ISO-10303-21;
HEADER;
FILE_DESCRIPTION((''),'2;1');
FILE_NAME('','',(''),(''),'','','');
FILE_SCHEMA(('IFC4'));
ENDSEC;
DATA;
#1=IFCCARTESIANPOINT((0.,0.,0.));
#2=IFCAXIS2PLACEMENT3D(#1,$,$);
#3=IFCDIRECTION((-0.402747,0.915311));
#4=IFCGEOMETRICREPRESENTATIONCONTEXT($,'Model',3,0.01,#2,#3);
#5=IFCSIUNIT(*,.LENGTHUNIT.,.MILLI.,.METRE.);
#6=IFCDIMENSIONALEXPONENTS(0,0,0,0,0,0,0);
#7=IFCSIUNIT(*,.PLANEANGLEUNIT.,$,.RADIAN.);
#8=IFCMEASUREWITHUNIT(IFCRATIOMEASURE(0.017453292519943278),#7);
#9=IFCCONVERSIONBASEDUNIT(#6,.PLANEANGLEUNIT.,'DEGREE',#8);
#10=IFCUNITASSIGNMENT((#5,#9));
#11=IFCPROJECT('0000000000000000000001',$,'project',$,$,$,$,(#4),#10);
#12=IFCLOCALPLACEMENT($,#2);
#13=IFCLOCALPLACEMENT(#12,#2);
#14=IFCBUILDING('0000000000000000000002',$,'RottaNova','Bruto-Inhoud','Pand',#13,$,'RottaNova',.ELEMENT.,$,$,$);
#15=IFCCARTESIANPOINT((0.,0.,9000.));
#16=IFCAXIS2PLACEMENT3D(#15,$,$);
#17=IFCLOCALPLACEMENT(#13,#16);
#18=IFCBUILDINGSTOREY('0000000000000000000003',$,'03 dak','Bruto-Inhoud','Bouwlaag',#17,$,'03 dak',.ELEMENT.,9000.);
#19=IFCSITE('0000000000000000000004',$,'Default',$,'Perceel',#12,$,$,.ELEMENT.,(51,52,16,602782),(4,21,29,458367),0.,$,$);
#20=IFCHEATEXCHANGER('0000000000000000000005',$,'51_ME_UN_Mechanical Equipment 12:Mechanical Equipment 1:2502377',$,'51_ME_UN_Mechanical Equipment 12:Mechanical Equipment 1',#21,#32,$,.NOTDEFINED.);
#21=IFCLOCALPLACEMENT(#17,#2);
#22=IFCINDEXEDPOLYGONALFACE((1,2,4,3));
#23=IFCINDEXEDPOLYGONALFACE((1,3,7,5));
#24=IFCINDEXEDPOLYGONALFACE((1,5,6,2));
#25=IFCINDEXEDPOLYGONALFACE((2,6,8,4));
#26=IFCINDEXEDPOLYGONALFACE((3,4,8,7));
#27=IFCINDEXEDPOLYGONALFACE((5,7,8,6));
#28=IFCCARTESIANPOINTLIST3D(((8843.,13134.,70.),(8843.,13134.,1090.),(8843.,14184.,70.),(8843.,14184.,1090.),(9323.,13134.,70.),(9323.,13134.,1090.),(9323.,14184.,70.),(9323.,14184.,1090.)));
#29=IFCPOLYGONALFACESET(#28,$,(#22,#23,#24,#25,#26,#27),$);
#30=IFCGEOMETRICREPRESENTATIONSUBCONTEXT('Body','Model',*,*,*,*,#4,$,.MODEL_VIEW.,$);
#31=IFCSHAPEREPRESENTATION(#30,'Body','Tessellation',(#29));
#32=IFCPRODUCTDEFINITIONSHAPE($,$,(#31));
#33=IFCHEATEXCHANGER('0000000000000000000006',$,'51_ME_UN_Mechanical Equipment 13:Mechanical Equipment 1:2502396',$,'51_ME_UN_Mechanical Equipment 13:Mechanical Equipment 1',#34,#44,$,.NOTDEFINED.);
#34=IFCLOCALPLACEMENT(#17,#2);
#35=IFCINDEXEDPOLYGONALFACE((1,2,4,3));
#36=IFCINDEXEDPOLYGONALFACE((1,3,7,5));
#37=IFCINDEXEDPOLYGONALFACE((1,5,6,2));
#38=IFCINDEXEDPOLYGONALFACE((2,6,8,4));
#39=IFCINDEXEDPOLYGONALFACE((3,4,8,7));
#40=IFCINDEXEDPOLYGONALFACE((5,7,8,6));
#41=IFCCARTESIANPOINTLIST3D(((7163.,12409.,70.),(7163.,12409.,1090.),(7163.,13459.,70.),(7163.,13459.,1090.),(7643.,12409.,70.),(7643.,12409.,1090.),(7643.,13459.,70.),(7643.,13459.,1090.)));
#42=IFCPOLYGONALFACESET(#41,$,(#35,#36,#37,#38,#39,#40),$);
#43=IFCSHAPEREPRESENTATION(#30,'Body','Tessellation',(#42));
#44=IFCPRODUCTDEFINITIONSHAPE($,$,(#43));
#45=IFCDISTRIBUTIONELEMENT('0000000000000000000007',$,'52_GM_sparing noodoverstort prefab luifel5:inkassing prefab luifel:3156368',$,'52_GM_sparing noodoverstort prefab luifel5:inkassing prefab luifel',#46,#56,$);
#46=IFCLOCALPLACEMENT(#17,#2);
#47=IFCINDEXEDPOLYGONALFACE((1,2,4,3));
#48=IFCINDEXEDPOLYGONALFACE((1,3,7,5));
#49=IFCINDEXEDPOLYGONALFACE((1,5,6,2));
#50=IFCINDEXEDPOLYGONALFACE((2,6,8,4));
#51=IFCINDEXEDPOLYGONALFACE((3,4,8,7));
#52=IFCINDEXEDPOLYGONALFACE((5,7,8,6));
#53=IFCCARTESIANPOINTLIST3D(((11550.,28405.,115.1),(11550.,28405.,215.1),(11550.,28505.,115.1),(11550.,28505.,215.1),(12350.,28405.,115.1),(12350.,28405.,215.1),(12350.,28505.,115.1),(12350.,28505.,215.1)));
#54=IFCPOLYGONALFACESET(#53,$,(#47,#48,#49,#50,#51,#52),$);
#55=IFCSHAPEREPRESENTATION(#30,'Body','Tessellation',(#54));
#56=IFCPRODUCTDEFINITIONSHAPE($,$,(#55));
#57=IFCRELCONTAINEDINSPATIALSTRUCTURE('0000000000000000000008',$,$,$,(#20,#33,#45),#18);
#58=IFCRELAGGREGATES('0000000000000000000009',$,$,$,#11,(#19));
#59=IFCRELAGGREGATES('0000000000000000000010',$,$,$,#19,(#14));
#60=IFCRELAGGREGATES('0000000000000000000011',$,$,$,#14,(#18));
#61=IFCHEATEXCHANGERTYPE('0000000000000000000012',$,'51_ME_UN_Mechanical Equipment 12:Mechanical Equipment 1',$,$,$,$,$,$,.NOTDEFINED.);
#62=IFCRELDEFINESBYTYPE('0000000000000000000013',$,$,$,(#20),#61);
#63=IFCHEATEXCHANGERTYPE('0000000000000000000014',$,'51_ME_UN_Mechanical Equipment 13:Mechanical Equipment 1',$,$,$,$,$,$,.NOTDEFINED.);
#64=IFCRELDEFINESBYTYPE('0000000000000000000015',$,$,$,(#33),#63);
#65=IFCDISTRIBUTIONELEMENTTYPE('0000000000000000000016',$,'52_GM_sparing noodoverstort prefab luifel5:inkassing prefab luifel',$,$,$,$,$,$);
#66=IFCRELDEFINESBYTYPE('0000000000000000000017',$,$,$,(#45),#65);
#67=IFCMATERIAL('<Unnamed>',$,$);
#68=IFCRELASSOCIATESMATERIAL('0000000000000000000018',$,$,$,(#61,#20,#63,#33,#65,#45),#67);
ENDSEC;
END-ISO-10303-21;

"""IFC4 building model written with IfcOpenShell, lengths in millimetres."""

from ifc_helpers import new_model, entity, si_unit, converted_unit, direction, frame, frame_2d, origin, origin_2d_with_axis, place, context, subcontext, project, spatial, rectangle, extrude, source, transform, mapped, material, type_object, type_shapes, element, save


model = new_model("IFC4")

# Units and contexts
model_context = context("Model", 3, precision=0.01, world=origin(), true_north=direction((-0.402747, 0.915311)))
body_context = subcontext(model_context, "Body", "Model", "MODEL_VIEW")
ifc_project = project(units=[si_unit("LENGTHUNIT", "METRE", prefix="MILLI"), converted_unit("PLANEANGLEUNIT", "DEGREE", entity("IfcRatioMeasure", 0.017453292519943278), si_unit("PLANEANGLEUNIT", "RADIAN"), dimensions=[0, 0, 0, 0, 0, 0, 0])], contexts=[model_context])

# Site, building, storey
site_placement = place(None, origin())
site = spatial("IfcSite", under=ifc_project, at=site_placement, Name="Default", ObjectType="Perceel", CompositionType="ELEMENT", RefLatitude=(51, 52, 16, 602782), RefLongitude=(4, 21, 29, 458367), RefElevation=0.0)
building_placement = place(site_placement, origin())
building = spatial("IfcBuilding", under=site, at=building_placement, Name="RottaNova", Description="Bruto-Inhoud", ObjectType="Pand", LongName="RottaNova", CompositionType="ELEMENT")
storey_placement = place(building_placement, frame((0.0, 0.0, 9000.0)))
storey = spatial("IfcBuildingStorey", under=building, at=storey_placement, Name="03 dak", Description="Bruto-Inhoud", ObjectType="Bouwlaag", LongName="03 dak", CompositionType="ELEMENT", Elevation=9000.0)

# Heat exchangers
ifc_material_1 = material(Name="<Unnamed>")
heat_exchanger_type_1 = type_object("IfcHeatExchangerType", Name="51_ME_UN_Mechanical Equipment 12:Mechanical Equipment 1", PredefinedType="NOTDEFINED", material=ifc_material_1)
shared_shape_1 = source(origin(), body_context, "Body", "SweptSolid", [
    extrude(rectangle(XDim=1050.0, YDim=480.0, at=frame_2d((0.0, 0.0), x_axis=(1.0, 0.0))), frame((525.0, 240.0, 0.0), z_axis=(0.0, 0.0, 1.0), x_axis=(-1.0, 0.0, 0.0)), (0.0, 0.0, 1.0), 1020.0),
])
type_shapes(heat_exchanger_type_1, [shared_shape_1])
heat_exchanger_1_placement = place(storey_placement, frame((9323.0, 13134.0, 70.0), z_axis=(0.0, 0.0, 1.0), x_axis=(0.0, 1.0, 0.0)))
element("IfcHeatExchanger", 1, at=heat_exchanger_1_placement, inside=storey, type_object=heat_exchanger_type_1, material=ifc_material_1, Name="51_ME_UN_Mechanical Equipment 12:Mechanical Equipment 1:2502377", ObjectType="51_ME_UN_Mechanical Equipment 12:Mechanical Equipment 1", PredefinedType="NOTDEFINED", context=body_context, shape_type="MappedRepresentation", body=[
    mapped(shared_shape_1, transform((0.0, 0.0, 0.0), scale=1.0)),
])
heat_exchanger_type_2 = type_object("IfcHeatExchangerType", Name="51_ME_UN_Mechanical Equipment 13:Mechanical Equipment 1", PredefinedType="NOTDEFINED", material=ifc_material_1)
shared_shape_2 = source(origin(), body_context, "Body", "SweptSolid", [
    extrude(rectangle(XDim=1050.0, YDim=480.0, at=frame_2d((0.0, 0.0), x_axis=(1.0, 0.0))), frame((525.0, 240.0, 0.0), z_axis=(0.0, 0.0, 1.0), x_axis=(-1.0, 0.0, 0.0)), (0.0, 0.0, 1.0), 1020.0),
])
type_shapes(heat_exchanger_type_2, [shared_shape_2])
heat_exchanger_2_placement = place(storey_placement, frame((7643.0, 12409.0, 70.0), z_axis=(0.0, 0.0, 1.0), x_axis=(0.0, 1.0, 0.0)))
element("IfcHeatExchanger", 2, at=heat_exchanger_2_placement, inside=storey, type_object=heat_exchanger_type_2, material=ifc_material_1, Name="51_ME_UN_Mechanical Equipment 13:Mechanical Equipment 1:2502396", ObjectType="51_ME_UN_Mechanical Equipment 13:Mechanical Equipment 1", PredefinedType="NOTDEFINED", context=body_context, shape_type="MappedRepresentation", body=[
    mapped(shared_shape_2, transform((0.0, 0.0, 0.0), scale=1.0)),
])

# Distribution element
distribution_element_type = type_object("IfcDistributionElementType", Name="52_GM_sparing noodoverstort prefab luifel5:inkassing prefab luifel", material=ifc_material_1)
shared_shape_3 = source(origin(), body_context, "Body", "SweptSolid", [
    extrude(rectangle(XDim=100.0, YDim=800.0, at=origin_2d_with_axis()), frame((400.0, 50.0, 0.0), z_axis=(0.0, 0.0, 1.0), x_axis=(0.0, -1.0, 0.0)), (0.0, 0.0, 1.0), 100.0),
])
type_shapes(distribution_element_type, [shared_shape_3])
distribution_element_placement = place(storey_placement, frame((11550.0, 28405.0, 115.1)))
element("IfcDistributionElement", 3, at=distribution_element_placement, inside=storey, type_object=distribution_element_type, material=ifc_material_1, Name="52_GM_sparing noodoverstort prefab luifel5:inkassing prefab luifel:3156368", ObjectType="52_GM_sparing noodoverstort prefab luifel5:inkassing prefab luifel", context=body_context, shape_type="MappedRepresentation", body=[
    mapped(shared_shape_3, transform((0.0, 0.0, 0.0), scale=1.0)),
])

save(model, "model.ifc")
